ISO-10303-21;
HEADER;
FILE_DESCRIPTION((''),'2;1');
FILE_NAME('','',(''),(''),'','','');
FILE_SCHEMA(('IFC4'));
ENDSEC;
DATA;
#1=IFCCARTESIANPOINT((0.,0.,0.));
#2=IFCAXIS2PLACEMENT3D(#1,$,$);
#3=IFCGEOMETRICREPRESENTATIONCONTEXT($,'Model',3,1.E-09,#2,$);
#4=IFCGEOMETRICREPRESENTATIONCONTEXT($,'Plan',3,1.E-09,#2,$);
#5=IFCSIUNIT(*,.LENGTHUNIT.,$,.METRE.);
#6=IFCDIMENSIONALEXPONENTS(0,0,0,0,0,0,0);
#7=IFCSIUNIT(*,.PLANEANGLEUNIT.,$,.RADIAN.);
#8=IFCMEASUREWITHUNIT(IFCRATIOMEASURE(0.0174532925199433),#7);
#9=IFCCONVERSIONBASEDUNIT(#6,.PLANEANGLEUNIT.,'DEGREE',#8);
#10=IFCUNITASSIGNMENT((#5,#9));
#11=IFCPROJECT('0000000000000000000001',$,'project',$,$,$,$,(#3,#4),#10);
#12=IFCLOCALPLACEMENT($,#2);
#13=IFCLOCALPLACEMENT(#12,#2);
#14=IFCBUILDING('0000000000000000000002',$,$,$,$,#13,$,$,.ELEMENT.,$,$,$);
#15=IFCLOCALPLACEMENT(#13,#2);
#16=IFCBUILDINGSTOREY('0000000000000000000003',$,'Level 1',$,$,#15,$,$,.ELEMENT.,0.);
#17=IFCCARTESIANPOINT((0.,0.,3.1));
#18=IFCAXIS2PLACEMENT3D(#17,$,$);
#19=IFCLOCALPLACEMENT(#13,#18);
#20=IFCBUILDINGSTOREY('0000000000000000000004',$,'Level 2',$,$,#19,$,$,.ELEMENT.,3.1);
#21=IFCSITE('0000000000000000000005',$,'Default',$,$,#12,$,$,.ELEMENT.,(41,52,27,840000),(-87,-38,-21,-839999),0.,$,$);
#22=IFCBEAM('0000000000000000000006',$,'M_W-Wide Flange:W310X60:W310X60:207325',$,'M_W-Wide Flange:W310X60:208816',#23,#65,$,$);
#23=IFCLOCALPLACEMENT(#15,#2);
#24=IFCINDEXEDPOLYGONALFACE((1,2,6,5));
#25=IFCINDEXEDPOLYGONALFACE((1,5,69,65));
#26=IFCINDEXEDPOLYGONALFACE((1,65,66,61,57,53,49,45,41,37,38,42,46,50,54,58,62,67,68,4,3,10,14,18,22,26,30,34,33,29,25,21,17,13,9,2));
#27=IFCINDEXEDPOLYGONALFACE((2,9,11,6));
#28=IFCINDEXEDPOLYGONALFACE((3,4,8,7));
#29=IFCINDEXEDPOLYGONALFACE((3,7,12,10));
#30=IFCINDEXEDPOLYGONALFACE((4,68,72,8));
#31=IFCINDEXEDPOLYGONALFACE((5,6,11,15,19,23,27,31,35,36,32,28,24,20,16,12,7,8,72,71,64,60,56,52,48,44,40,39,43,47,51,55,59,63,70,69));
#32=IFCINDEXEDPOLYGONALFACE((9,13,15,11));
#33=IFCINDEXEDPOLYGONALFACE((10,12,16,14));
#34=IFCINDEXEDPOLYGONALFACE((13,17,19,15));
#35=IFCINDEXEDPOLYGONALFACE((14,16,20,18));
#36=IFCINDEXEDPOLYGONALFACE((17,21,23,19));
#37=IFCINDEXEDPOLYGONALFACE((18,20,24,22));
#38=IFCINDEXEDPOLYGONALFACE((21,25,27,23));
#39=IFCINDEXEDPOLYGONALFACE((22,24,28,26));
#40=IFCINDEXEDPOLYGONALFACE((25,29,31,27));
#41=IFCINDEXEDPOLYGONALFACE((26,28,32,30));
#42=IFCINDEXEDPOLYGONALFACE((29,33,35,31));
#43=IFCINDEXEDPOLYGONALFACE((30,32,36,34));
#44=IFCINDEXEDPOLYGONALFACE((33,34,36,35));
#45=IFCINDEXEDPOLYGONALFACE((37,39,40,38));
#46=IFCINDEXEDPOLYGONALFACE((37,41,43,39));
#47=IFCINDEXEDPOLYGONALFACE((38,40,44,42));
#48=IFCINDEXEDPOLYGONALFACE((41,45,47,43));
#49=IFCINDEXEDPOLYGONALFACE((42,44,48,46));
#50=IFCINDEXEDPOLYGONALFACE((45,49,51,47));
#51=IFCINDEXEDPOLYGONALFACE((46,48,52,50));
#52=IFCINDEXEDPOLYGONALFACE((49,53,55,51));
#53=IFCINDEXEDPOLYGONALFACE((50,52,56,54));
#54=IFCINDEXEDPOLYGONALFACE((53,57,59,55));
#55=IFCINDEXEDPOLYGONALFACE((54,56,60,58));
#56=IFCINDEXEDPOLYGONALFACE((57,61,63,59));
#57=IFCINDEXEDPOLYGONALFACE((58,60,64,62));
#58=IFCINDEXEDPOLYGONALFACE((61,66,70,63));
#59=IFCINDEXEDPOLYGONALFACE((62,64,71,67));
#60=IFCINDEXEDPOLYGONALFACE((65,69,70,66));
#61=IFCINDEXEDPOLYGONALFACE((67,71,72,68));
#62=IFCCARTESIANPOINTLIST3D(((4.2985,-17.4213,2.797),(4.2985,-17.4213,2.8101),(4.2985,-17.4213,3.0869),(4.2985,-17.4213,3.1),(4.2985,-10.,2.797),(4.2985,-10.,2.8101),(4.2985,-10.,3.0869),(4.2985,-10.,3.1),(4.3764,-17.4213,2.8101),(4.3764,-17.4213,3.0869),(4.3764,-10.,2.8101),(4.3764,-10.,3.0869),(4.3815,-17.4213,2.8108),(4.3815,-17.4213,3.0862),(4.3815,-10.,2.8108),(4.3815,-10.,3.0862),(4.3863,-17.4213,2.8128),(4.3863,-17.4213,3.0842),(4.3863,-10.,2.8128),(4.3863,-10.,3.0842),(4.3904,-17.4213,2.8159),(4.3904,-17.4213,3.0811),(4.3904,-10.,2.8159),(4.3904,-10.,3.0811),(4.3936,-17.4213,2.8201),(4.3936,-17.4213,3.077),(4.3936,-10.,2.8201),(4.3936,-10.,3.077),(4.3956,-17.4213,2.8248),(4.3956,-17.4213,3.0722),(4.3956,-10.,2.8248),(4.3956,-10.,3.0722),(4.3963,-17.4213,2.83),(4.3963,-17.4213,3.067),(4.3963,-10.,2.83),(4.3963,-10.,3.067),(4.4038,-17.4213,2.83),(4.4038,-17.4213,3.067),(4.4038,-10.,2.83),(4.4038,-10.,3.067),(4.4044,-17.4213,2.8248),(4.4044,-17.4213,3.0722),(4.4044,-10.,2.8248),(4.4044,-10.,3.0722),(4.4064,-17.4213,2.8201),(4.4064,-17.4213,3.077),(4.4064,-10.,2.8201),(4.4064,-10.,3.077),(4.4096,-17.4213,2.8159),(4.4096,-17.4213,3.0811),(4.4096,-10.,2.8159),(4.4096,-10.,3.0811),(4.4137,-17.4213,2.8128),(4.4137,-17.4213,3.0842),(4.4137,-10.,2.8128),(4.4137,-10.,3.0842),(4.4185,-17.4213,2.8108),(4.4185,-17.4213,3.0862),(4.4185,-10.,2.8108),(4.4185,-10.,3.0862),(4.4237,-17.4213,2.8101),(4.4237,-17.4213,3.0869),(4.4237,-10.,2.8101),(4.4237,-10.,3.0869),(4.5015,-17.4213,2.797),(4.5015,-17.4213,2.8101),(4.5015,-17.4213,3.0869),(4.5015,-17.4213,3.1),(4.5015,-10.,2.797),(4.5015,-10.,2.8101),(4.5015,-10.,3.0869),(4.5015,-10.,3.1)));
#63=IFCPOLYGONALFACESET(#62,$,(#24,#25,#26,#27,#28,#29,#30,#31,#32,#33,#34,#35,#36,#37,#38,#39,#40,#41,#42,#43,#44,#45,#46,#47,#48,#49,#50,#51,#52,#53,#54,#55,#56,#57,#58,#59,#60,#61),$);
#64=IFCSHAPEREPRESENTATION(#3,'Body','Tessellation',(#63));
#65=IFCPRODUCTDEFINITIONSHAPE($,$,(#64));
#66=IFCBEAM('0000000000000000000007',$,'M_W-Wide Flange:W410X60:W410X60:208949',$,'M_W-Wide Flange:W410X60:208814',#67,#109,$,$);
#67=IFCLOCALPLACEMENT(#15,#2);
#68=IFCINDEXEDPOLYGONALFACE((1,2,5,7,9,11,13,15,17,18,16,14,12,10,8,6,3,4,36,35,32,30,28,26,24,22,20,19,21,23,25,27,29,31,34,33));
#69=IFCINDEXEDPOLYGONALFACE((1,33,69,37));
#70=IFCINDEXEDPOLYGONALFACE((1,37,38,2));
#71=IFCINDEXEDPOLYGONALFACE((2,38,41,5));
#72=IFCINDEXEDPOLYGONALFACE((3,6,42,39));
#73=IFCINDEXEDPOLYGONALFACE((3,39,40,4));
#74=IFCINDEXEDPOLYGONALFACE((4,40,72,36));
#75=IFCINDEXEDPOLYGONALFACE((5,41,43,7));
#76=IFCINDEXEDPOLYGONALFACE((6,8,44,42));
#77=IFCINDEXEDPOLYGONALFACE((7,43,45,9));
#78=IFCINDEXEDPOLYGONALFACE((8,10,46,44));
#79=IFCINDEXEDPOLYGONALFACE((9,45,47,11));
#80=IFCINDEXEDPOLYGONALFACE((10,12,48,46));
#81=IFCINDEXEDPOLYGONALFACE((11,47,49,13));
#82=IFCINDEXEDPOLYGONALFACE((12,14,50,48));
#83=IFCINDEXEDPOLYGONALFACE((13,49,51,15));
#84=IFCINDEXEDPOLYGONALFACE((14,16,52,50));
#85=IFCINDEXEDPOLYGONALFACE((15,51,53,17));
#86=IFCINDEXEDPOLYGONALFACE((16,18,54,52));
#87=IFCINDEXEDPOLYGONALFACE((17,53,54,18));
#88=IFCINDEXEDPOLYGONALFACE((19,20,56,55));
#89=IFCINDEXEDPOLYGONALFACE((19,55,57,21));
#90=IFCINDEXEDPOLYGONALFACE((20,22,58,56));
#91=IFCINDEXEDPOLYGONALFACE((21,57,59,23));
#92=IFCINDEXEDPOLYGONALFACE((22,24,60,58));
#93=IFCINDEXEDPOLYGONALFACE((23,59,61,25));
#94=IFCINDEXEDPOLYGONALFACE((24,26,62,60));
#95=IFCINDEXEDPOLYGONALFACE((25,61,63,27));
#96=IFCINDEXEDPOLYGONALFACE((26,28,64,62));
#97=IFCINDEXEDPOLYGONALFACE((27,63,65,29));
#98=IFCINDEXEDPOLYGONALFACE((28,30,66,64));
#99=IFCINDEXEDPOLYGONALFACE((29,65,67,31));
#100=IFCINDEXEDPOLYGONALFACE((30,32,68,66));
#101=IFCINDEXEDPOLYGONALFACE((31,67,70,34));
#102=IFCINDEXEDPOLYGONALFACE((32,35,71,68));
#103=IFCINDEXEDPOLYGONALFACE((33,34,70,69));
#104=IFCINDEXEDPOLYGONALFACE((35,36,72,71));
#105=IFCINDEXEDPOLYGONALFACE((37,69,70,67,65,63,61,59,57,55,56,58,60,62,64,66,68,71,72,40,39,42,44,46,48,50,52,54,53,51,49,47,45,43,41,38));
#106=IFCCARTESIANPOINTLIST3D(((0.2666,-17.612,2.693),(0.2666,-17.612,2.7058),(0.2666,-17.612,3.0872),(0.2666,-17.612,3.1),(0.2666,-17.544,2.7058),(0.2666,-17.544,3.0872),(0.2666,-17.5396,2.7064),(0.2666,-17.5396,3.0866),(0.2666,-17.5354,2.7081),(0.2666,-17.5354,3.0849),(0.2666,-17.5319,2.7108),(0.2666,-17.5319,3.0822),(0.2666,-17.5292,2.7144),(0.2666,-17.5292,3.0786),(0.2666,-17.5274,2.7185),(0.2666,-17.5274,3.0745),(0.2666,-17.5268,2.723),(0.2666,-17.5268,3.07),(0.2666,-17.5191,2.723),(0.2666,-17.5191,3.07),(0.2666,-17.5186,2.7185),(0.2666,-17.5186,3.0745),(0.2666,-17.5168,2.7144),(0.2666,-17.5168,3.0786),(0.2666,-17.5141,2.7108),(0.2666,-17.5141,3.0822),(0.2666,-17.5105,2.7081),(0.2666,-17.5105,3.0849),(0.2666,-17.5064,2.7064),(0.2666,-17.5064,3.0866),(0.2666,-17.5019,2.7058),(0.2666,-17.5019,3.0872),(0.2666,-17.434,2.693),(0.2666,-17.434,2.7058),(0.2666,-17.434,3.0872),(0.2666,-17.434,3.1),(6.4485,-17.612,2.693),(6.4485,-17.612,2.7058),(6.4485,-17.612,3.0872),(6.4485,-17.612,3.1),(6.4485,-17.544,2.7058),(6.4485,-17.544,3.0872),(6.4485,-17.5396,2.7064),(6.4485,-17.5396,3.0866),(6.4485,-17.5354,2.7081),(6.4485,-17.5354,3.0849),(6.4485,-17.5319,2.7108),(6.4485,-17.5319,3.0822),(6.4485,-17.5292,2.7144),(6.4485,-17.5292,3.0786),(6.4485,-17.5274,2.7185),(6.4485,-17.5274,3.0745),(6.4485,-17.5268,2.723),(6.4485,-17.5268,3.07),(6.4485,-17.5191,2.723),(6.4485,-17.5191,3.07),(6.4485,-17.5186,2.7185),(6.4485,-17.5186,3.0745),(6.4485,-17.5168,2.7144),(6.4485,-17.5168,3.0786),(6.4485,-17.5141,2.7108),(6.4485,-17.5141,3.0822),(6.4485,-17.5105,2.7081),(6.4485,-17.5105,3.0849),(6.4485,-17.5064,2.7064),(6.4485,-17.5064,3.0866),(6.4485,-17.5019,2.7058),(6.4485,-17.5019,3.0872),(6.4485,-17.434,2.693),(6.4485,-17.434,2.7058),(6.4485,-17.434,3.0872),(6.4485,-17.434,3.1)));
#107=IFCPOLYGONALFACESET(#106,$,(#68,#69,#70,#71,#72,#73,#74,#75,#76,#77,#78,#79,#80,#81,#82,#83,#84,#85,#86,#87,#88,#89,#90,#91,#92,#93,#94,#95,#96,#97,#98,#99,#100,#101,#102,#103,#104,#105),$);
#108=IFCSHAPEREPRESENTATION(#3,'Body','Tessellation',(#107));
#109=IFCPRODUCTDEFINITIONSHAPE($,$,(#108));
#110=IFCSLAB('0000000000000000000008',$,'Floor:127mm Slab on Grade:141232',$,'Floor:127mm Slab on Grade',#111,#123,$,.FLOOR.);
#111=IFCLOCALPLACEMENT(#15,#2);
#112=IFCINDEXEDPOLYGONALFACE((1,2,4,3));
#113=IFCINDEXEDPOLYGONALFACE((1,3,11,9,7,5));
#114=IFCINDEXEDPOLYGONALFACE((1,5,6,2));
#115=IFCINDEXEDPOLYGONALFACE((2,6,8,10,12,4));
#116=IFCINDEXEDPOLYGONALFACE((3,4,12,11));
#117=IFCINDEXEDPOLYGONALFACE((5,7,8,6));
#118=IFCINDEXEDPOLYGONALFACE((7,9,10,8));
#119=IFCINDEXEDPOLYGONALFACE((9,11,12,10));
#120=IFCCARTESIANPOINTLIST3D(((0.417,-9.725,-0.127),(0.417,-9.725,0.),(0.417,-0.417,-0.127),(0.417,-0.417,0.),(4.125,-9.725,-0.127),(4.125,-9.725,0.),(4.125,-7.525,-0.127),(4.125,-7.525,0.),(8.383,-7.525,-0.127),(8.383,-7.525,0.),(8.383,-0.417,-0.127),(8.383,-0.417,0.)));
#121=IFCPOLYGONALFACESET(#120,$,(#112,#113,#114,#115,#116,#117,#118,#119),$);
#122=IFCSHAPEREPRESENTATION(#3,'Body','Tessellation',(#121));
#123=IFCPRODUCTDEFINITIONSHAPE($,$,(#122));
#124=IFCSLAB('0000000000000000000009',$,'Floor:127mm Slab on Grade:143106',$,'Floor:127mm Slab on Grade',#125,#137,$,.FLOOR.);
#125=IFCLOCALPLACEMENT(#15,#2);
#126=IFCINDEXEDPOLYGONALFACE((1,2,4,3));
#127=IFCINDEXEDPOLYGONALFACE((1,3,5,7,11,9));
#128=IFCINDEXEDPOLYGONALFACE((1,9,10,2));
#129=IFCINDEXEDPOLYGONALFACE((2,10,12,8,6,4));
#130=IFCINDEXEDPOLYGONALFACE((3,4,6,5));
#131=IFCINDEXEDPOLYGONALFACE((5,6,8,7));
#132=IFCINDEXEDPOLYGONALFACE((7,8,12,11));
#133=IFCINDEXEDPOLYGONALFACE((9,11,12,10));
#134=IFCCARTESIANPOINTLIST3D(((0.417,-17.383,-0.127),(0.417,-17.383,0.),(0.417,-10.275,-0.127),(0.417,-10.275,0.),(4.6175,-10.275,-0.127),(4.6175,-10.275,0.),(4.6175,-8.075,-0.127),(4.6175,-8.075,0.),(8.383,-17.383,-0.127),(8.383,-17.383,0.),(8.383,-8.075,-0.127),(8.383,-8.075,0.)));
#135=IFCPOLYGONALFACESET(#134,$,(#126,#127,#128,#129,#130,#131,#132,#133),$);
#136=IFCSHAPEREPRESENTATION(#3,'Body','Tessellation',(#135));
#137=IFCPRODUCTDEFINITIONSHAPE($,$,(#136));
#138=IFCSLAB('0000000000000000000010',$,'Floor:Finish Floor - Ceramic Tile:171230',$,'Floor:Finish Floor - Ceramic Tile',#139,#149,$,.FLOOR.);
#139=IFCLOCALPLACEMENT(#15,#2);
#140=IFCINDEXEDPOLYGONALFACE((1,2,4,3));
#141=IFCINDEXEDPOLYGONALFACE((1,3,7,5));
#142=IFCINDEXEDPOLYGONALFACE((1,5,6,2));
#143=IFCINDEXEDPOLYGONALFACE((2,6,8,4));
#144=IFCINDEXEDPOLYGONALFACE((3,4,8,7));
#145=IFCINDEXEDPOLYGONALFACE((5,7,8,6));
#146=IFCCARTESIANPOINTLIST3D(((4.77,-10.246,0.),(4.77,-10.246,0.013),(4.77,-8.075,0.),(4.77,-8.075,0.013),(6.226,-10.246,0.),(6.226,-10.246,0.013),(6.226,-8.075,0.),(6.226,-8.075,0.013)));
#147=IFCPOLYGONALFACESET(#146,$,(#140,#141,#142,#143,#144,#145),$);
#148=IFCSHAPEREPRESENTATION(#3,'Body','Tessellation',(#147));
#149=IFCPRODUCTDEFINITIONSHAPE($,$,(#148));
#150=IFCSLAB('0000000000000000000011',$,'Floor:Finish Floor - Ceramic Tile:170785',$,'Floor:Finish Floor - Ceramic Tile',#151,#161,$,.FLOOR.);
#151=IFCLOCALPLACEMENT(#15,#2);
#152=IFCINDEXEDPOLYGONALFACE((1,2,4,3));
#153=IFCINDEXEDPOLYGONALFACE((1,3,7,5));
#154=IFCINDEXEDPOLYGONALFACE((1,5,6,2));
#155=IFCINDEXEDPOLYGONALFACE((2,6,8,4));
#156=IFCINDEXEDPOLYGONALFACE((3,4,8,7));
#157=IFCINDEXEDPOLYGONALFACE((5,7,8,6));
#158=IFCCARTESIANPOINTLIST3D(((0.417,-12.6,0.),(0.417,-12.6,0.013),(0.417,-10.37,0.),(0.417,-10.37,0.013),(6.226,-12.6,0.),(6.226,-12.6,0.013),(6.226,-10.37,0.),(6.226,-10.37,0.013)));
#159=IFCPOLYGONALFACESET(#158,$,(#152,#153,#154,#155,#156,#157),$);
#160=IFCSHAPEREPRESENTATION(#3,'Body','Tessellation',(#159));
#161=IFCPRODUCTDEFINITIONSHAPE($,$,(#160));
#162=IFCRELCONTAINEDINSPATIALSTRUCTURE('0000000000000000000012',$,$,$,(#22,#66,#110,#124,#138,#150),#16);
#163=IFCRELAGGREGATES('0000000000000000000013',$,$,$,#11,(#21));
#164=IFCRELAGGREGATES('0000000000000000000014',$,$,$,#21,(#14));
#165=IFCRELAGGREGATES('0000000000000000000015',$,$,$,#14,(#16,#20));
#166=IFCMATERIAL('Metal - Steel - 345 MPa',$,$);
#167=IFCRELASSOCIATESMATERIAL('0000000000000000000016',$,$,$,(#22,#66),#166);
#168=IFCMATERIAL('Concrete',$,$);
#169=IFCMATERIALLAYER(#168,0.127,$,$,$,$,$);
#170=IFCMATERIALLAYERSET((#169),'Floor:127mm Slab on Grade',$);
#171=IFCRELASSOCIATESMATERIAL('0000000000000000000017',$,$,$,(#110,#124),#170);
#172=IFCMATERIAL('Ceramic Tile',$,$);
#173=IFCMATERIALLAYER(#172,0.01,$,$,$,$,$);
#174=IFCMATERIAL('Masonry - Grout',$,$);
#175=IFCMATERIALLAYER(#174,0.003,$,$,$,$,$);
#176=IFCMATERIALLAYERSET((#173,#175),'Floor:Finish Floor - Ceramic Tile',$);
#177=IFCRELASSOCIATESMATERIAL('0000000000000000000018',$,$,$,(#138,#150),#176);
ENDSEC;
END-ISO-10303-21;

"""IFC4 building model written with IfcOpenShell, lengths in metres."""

from ifc_helpers import new_model, entity, si_unit, converted_unit, frame, frame_2d, origin, place, context, project, spatial, polyline, circle_curve, parameter, trimmed, segment, composite_curve, rectangle, outline, extrude, material, layer, layer_set, layer_usage, element, save


model = new_model("IFC4")

# Units and contexts
model_context = context("Model", 3, precision=1e-09, world=origin())
plan_context = context("Plan", 3, precision=1e-09, world=origin())
ifc_project = project(units=[si_unit("LENGTHUNIT", "METRE"), converted_unit("PLANEANGLEUNIT", "DEGREE", entity("IfcRatioMeasure", 0.0174532925199433), si_unit("PLANEANGLEUNIT", "RADIAN"), dimensions=[0, 0, 0, 0, 0, 0, 0])], contexts=[model_context, plan_context])

# Site, building, storey
site_placement = place(None, origin())
site = spatial("IfcSite", under=ifc_project, at=site_placement, Name="Default", CompositionType="ELEMENT", RefLatitude=(41, 52, 27, 840000), RefLongitude=(-87, -38, -21, -839999), RefElevation=0.0)
building_placement = place(site_placement, origin())
building = spatial("IfcBuilding", under=site, at=building_placement, CompositionType="ELEMENT")
storey_1_placement = place(building_placement, origin())
storey_1 = spatial("IfcBuildingStorey", under=building, at=storey_1_placement, Name="Level 1", CompositionType="ELEMENT", Elevation=0.0)

# Beams
ifc_material_1 = material(Name="Metal - Steel - 345 MPa")
beam_1_placement = place(storey_1_placement, frame((4.4, -10.0, 3.1), z_axis=(0.0, 0.0, 1.0), x_axis=(-1.0, 0.0, 0.0)))
element("IfcBeam", 1, at=beam_1_placement, inside=storey_1, material=ifc_material_1, Name="M_W-Wide Flange:W310X60:W310X60:207325", ObjectType="M_W-Wide Flange:W310X60:208816", context=model_context, shape_type="SweptSolid", body=[
    extrude(outline(composite_curve([segment(polyline([(0.1384, -0.1015), (0.1515, -0.1015)]), True, "CONTINUOUS"), segment(polyline([(0.1515, -0.1015), (0.1515, 0.1015)]), True, "CONTINUOUS"), segment(polyline([(0.1515, 0.1015), (0.1384, 0.1015)]), True, "CONTINUOUS"), segment(polyline([(0.1384, 0.1015), (0.1384, 0.0236)]), True, "CONTINUOUS"), segment(trimmed(circle_curve(frame_2d((0.1185, 0.0236), x_axis=(0.0, 1.0)), 0.0199), [parameter(180.0)], [parameter(270.0)], True, "PARAMETER"), False, "CONTINUOUS"), segment(polyline([(0.1185, 0.0037), (-0.1185, 0.0037)]), True, "CONTINUOUS"), segment(trimmed(circle_curve(frame_2d((-0.1185, 0.0236), x_axis=(0.0, 1.0)), 0.0199), [parameter(90.0)], [parameter(180.0)], True, "PARAMETER"), False, "CONTINUOUS"), segment(polyline([(-0.1384, 0.0236), (-0.1384, 0.1015)]), True, "CONTINUOUS"), segment(polyline([(-0.1384, 0.1015), (-0.1515, 0.1015)]), True, "CONTINUOUS"), segment(polyline([(-0.1515, 0.1015), (-0.1515, -0.1015)]), True, "CONTINUOUS"), segment(polyline([(-0.1515, -0.1015), (-0.1384, -0.1015)]), True, "CONTINUOUS"), segment(polyline([(-0.1384, -0.1015), (-0.1384, -0.0237)]), True, "CONTINUOUS"), segment(trimmed(circle_curve(frame_2d((-0.1185, -0.0237), x_axis=(0.0, 1.0)), 0.0199), [parameter(360.0)], [parameter(90.0)], True, "PARAMETER"), False, "CONTINUOUS"), segment(polyline([(-0.1185, -0.0038), (0.1185, -0.0038)]), True, "CONTINUOUS"), segment(trimmed(circle_curve(frame_2d((0.1185, -0.0237), x_axis=(0.0, 1.0)), 0.0199), [parameter(270.0)], [parameter(0.0)], True, "PARAMETER"), False, "CONTINUOUS"), segment(polyline([(0.1384, -0.0237), (0.1384, -0.1015)]), True, "CONTINUOUS")], self_intersect=False)), frame((0.0, 7.4213, -0.1515), z_axis=(0.0, -1.0, 0.0), x_axis=(0.0, 0.0, -1.0)), (0.0, 0.0, 1.0), 7.4213),
])
beam_2_placement = place(storey_1_placement, frame((0.2085, -17.523, 3.1), z_axis=(0.0, 0.0, 1.0), x_axis=(0.0, -1.0, 0.0)))
element("IfcBeam", 2, at=beam_2_placement, inside=storey_1, material=ifc_material_1, Name="M_W-Wide Flange:W410X60:W410X60:208949", ObjectType="M_W-Wide Flange:W410X60:208814", context=model_context, shape_type="SweptSolid", body=[
    extrude(outline(composite_curve([segment(polyline([(-0.089, -0.1907), (-0.089, -0.2035)]), True, "CONTINUOUS"), segment(polyline([(-0.089, -0.2035), (0.089, -0.2035)]), True, "CONTINUOUS"), segment(polyline([(0.089, -0.2035), (0.089, -0.1907)]), True, "CONTINUOUS"), segment(polyline([(0.089, -0.1907), (0.021, -0.1907)]), True, "CONTINUOUS"), segment(trimmed(circle_curve(frame_2d((0.021, -0.1735), x_axis=(0.0, -1.0)), 0.0172), [parameter(270.0)], [parameter(360.0)], True, "PARAMETER"), False, "CONTINUOUS"), segment(polyline([(0.0038, -0.1735), (0.0038, 0.1735)]), True, "CONTINUOUS"), segment(trimmed(circle_curve(frame_2d((0.021, 0.1735), x_axis=(-1.0, 0.0)), 0.0172), [parameter(270.0)], [parameter(360.0)], True, "PARAMETER"), False, "CONTINUOUS"), segment(polyline([(0.021, 0.1907), (0.089, 0.1907)]), True, "CONTINUOUS"), segment(polyline([(0.089, 0.1907), (0.089, 0.2035)]), True, "CONTINUOUS"), segment(polyline([(0.089, 0.2035), (-0.089, 0.2035)]), True, "CONTINUOUS"), segment(polyline([(-0.089, 0.2035), (-0.089, 0.1907)]), True, "CONTINUOUS"), segment(polyline([(-0.089, 0.1907), (-0.0211, 0.1907)]), True, "CONTINUOUS"), segment(trimmed(circle_curve(frame_2d((-0.0211, 0.1735), x_axis=(0.0, 1.0)), 0.0172), [parameter(270.0)], [parameter(0.0)], True, "PARAMETER"), False, "CONTINUOUS"), segment(polyline([(-0.0039, 0.1735), (-0.0039, -0.1735)]), True, "CONTINUOUS"), segment(trimmed(circle_curve(frame_2d((-0.0211, -0.1735), x_axis=(1.0, 0.0)), 0.0172), [parameter(270.0)], [parameter(0.0)], True, "PARAMETER"), False, "CONTINUOUS"), segment(polyline([(-0.0211, -0.1907), (-0.089, -0.1907)]), True, "CONTINUOUS")], self_intersect=False)), frame((0.0, 0.0581, -0.2035), z_axis=(0.0, -1.0, 0.0), x_axis=(1.0, 0.0, 0.0)), (0.0, 0.0, -1.0), 6.1819),
])

# Slabs
ifc_material_2 = material(Name="Concrete")
ifc_layer_1 = layer(ifc_material_2, 0.127)
ifc_layer_set_1 = layer_set([ifc_layer_1], Name="Floor:127mm Slab on Grade")
ifc_layer_usage_1 = layer_usage(ifc_layer_set_1, "AXIS3", "POSITIVE", 0.0)
slab_1_placement = place(storey_1_placement, frame((0.417, -9.725, -0.127)))
element("IfcSlab", 3, at=slab_1_placement, inside=storey_1, material=ifc_layer_usage_1, Name="Floor:127mm Slab on Grade:141232", ObjectType="Floor:127mm Slab on Grade", PredefinedType="FLOOR", context=model_context, shape_type="SweptSolid", body=[
    extrude(outline(polyline([(-3.983, 4.654), (-3.983, -2.454), (0.275, -2.454), (0.275, -4.654), (3.983, -4.654), (3.983, 4.654), (-3.983, 4.654)])), frame((3.983, 4.654, 0.127), z_axis=(0.0, 0.0, -1.0), x_axis=(-1.0, 0.0, 0.0)), (0.0, 0.0, 1.0), 0.127),
])
ifc_layer_usage_2 = layer_usage(ifc_layer_set_1, "AXIS3", "POSITIVE", 0.0)
slab_2_placement = place(storey_1_placement, frame((0.417, -17.383, -0.127)))
element("IfcSlab", 4, at=slab_2_placement, inside=storey_1, material=ifc_layer_usage_2, Name="Floor:127mm Slab on Grade:143106", ObjectType="Floor:127mm Slab on Grade", PredefinedType="FLOOR", context=model_context, shape_type="SweptSolid", body=[
    extrude(outline(polyline([(-3.983, 4.654), (-3.983, -4.654), (3.983, -4.654), (3.983, 2.454), (-0.2175, 2.454), (-0.2175, 4.654), (-3.983, 4.654)])), frame((3.983, 4.654, 0.127), z_axis=(0.0, 0.0, -1.0), x_axis=(-1.0, 0.0, 0.0)), (0.0, 0.0, 1.0), 0.127),
])
ifc_material_3 = material(Name="Ceramic Tile")
ifc_layer_2 = layer(ifc_material_3, 0.01)
ifc_material_4 = material(Name="Masonry - Grout")
ifc_layer_3 = layer(ifc_material_4, 0.003)
ifc_layer_set_2 = layer_set([ifc_layer_2, ifc_layer_3], Name="Floor:Finish Floor - Ceramic Tile")
ifc_layer_usage_3 = layer_usage(ifc_layer_set_2, "AXIS3", "POSITIVE", 0.0)
slab_3_placement = place(storey_1_placement, frame((4.77, -10.246, 0.0)))
element("IfcSlab", 5, at=slab_3_placement, inside=storey_1, material=ifc_layer_usage_3, Name="Floor:Finish Floor - Ceramic Tile:171230", ObjectType="Floor:Finish Floor - Ceramic Tile", PredefinedType="FLOOR", context=model_context, shape_type="SweptSolid", body=[
    extrude(rectangle(XDim=1.456, YDim=2.171, at=frame_2d((0.0, 0.0), x_axis=(-1.0, 0.0))), frame((0.728, 1.0855, 0.013), z_axis=(0.0, 0.0, -1.0), x_axis=(-1.0, 0.0, 0.0)), (0.0, 0.0, 1.0), 0.013),
])
ifc_layer_usage_4 = layer_usage(ifc_layer_set_2, "AXIS3", "POSITIVE", 0.0)
slab_4_placement = place(storey_1_placement, frame((0.417, -12.6, 0.0)))
element("IfcSlab", 6, at=slab_4_placement, inside=storey_1, material=ifc_layer_usage_4, Name="Floor:Finish Floor - Ceramic Tile:170785", ObjectType="Floor:Finish Floor - Ceramic Tile", PredefinedType="FLOOR", context=model_context, shape_type="SweptSolid", body=[
    extrude(rectangle(XDim=5.809, YDim=2.23, at=frame_2d((0.0, 0.0), x_axis=(-1.0, 0.0))), frame((2.9045, 1.115, 0.013), z_axis=(0.0, 0.0, -1.0), x_axis=(-1.0, 0.0, 0.0)), (0.0, 0.0, 1.0), 0.013),
])

# Shared definitions
storey_2_placement = place(building_placement, frame((0.0, 0.0, 3.1)))
storey_2 = spatial("IfcBuildingStorey", under=building, at=storey_2_placement, Name="Level 2", CompositionType="ELEMENT", Elevation=3.1)

save(model, "model.ifc")
